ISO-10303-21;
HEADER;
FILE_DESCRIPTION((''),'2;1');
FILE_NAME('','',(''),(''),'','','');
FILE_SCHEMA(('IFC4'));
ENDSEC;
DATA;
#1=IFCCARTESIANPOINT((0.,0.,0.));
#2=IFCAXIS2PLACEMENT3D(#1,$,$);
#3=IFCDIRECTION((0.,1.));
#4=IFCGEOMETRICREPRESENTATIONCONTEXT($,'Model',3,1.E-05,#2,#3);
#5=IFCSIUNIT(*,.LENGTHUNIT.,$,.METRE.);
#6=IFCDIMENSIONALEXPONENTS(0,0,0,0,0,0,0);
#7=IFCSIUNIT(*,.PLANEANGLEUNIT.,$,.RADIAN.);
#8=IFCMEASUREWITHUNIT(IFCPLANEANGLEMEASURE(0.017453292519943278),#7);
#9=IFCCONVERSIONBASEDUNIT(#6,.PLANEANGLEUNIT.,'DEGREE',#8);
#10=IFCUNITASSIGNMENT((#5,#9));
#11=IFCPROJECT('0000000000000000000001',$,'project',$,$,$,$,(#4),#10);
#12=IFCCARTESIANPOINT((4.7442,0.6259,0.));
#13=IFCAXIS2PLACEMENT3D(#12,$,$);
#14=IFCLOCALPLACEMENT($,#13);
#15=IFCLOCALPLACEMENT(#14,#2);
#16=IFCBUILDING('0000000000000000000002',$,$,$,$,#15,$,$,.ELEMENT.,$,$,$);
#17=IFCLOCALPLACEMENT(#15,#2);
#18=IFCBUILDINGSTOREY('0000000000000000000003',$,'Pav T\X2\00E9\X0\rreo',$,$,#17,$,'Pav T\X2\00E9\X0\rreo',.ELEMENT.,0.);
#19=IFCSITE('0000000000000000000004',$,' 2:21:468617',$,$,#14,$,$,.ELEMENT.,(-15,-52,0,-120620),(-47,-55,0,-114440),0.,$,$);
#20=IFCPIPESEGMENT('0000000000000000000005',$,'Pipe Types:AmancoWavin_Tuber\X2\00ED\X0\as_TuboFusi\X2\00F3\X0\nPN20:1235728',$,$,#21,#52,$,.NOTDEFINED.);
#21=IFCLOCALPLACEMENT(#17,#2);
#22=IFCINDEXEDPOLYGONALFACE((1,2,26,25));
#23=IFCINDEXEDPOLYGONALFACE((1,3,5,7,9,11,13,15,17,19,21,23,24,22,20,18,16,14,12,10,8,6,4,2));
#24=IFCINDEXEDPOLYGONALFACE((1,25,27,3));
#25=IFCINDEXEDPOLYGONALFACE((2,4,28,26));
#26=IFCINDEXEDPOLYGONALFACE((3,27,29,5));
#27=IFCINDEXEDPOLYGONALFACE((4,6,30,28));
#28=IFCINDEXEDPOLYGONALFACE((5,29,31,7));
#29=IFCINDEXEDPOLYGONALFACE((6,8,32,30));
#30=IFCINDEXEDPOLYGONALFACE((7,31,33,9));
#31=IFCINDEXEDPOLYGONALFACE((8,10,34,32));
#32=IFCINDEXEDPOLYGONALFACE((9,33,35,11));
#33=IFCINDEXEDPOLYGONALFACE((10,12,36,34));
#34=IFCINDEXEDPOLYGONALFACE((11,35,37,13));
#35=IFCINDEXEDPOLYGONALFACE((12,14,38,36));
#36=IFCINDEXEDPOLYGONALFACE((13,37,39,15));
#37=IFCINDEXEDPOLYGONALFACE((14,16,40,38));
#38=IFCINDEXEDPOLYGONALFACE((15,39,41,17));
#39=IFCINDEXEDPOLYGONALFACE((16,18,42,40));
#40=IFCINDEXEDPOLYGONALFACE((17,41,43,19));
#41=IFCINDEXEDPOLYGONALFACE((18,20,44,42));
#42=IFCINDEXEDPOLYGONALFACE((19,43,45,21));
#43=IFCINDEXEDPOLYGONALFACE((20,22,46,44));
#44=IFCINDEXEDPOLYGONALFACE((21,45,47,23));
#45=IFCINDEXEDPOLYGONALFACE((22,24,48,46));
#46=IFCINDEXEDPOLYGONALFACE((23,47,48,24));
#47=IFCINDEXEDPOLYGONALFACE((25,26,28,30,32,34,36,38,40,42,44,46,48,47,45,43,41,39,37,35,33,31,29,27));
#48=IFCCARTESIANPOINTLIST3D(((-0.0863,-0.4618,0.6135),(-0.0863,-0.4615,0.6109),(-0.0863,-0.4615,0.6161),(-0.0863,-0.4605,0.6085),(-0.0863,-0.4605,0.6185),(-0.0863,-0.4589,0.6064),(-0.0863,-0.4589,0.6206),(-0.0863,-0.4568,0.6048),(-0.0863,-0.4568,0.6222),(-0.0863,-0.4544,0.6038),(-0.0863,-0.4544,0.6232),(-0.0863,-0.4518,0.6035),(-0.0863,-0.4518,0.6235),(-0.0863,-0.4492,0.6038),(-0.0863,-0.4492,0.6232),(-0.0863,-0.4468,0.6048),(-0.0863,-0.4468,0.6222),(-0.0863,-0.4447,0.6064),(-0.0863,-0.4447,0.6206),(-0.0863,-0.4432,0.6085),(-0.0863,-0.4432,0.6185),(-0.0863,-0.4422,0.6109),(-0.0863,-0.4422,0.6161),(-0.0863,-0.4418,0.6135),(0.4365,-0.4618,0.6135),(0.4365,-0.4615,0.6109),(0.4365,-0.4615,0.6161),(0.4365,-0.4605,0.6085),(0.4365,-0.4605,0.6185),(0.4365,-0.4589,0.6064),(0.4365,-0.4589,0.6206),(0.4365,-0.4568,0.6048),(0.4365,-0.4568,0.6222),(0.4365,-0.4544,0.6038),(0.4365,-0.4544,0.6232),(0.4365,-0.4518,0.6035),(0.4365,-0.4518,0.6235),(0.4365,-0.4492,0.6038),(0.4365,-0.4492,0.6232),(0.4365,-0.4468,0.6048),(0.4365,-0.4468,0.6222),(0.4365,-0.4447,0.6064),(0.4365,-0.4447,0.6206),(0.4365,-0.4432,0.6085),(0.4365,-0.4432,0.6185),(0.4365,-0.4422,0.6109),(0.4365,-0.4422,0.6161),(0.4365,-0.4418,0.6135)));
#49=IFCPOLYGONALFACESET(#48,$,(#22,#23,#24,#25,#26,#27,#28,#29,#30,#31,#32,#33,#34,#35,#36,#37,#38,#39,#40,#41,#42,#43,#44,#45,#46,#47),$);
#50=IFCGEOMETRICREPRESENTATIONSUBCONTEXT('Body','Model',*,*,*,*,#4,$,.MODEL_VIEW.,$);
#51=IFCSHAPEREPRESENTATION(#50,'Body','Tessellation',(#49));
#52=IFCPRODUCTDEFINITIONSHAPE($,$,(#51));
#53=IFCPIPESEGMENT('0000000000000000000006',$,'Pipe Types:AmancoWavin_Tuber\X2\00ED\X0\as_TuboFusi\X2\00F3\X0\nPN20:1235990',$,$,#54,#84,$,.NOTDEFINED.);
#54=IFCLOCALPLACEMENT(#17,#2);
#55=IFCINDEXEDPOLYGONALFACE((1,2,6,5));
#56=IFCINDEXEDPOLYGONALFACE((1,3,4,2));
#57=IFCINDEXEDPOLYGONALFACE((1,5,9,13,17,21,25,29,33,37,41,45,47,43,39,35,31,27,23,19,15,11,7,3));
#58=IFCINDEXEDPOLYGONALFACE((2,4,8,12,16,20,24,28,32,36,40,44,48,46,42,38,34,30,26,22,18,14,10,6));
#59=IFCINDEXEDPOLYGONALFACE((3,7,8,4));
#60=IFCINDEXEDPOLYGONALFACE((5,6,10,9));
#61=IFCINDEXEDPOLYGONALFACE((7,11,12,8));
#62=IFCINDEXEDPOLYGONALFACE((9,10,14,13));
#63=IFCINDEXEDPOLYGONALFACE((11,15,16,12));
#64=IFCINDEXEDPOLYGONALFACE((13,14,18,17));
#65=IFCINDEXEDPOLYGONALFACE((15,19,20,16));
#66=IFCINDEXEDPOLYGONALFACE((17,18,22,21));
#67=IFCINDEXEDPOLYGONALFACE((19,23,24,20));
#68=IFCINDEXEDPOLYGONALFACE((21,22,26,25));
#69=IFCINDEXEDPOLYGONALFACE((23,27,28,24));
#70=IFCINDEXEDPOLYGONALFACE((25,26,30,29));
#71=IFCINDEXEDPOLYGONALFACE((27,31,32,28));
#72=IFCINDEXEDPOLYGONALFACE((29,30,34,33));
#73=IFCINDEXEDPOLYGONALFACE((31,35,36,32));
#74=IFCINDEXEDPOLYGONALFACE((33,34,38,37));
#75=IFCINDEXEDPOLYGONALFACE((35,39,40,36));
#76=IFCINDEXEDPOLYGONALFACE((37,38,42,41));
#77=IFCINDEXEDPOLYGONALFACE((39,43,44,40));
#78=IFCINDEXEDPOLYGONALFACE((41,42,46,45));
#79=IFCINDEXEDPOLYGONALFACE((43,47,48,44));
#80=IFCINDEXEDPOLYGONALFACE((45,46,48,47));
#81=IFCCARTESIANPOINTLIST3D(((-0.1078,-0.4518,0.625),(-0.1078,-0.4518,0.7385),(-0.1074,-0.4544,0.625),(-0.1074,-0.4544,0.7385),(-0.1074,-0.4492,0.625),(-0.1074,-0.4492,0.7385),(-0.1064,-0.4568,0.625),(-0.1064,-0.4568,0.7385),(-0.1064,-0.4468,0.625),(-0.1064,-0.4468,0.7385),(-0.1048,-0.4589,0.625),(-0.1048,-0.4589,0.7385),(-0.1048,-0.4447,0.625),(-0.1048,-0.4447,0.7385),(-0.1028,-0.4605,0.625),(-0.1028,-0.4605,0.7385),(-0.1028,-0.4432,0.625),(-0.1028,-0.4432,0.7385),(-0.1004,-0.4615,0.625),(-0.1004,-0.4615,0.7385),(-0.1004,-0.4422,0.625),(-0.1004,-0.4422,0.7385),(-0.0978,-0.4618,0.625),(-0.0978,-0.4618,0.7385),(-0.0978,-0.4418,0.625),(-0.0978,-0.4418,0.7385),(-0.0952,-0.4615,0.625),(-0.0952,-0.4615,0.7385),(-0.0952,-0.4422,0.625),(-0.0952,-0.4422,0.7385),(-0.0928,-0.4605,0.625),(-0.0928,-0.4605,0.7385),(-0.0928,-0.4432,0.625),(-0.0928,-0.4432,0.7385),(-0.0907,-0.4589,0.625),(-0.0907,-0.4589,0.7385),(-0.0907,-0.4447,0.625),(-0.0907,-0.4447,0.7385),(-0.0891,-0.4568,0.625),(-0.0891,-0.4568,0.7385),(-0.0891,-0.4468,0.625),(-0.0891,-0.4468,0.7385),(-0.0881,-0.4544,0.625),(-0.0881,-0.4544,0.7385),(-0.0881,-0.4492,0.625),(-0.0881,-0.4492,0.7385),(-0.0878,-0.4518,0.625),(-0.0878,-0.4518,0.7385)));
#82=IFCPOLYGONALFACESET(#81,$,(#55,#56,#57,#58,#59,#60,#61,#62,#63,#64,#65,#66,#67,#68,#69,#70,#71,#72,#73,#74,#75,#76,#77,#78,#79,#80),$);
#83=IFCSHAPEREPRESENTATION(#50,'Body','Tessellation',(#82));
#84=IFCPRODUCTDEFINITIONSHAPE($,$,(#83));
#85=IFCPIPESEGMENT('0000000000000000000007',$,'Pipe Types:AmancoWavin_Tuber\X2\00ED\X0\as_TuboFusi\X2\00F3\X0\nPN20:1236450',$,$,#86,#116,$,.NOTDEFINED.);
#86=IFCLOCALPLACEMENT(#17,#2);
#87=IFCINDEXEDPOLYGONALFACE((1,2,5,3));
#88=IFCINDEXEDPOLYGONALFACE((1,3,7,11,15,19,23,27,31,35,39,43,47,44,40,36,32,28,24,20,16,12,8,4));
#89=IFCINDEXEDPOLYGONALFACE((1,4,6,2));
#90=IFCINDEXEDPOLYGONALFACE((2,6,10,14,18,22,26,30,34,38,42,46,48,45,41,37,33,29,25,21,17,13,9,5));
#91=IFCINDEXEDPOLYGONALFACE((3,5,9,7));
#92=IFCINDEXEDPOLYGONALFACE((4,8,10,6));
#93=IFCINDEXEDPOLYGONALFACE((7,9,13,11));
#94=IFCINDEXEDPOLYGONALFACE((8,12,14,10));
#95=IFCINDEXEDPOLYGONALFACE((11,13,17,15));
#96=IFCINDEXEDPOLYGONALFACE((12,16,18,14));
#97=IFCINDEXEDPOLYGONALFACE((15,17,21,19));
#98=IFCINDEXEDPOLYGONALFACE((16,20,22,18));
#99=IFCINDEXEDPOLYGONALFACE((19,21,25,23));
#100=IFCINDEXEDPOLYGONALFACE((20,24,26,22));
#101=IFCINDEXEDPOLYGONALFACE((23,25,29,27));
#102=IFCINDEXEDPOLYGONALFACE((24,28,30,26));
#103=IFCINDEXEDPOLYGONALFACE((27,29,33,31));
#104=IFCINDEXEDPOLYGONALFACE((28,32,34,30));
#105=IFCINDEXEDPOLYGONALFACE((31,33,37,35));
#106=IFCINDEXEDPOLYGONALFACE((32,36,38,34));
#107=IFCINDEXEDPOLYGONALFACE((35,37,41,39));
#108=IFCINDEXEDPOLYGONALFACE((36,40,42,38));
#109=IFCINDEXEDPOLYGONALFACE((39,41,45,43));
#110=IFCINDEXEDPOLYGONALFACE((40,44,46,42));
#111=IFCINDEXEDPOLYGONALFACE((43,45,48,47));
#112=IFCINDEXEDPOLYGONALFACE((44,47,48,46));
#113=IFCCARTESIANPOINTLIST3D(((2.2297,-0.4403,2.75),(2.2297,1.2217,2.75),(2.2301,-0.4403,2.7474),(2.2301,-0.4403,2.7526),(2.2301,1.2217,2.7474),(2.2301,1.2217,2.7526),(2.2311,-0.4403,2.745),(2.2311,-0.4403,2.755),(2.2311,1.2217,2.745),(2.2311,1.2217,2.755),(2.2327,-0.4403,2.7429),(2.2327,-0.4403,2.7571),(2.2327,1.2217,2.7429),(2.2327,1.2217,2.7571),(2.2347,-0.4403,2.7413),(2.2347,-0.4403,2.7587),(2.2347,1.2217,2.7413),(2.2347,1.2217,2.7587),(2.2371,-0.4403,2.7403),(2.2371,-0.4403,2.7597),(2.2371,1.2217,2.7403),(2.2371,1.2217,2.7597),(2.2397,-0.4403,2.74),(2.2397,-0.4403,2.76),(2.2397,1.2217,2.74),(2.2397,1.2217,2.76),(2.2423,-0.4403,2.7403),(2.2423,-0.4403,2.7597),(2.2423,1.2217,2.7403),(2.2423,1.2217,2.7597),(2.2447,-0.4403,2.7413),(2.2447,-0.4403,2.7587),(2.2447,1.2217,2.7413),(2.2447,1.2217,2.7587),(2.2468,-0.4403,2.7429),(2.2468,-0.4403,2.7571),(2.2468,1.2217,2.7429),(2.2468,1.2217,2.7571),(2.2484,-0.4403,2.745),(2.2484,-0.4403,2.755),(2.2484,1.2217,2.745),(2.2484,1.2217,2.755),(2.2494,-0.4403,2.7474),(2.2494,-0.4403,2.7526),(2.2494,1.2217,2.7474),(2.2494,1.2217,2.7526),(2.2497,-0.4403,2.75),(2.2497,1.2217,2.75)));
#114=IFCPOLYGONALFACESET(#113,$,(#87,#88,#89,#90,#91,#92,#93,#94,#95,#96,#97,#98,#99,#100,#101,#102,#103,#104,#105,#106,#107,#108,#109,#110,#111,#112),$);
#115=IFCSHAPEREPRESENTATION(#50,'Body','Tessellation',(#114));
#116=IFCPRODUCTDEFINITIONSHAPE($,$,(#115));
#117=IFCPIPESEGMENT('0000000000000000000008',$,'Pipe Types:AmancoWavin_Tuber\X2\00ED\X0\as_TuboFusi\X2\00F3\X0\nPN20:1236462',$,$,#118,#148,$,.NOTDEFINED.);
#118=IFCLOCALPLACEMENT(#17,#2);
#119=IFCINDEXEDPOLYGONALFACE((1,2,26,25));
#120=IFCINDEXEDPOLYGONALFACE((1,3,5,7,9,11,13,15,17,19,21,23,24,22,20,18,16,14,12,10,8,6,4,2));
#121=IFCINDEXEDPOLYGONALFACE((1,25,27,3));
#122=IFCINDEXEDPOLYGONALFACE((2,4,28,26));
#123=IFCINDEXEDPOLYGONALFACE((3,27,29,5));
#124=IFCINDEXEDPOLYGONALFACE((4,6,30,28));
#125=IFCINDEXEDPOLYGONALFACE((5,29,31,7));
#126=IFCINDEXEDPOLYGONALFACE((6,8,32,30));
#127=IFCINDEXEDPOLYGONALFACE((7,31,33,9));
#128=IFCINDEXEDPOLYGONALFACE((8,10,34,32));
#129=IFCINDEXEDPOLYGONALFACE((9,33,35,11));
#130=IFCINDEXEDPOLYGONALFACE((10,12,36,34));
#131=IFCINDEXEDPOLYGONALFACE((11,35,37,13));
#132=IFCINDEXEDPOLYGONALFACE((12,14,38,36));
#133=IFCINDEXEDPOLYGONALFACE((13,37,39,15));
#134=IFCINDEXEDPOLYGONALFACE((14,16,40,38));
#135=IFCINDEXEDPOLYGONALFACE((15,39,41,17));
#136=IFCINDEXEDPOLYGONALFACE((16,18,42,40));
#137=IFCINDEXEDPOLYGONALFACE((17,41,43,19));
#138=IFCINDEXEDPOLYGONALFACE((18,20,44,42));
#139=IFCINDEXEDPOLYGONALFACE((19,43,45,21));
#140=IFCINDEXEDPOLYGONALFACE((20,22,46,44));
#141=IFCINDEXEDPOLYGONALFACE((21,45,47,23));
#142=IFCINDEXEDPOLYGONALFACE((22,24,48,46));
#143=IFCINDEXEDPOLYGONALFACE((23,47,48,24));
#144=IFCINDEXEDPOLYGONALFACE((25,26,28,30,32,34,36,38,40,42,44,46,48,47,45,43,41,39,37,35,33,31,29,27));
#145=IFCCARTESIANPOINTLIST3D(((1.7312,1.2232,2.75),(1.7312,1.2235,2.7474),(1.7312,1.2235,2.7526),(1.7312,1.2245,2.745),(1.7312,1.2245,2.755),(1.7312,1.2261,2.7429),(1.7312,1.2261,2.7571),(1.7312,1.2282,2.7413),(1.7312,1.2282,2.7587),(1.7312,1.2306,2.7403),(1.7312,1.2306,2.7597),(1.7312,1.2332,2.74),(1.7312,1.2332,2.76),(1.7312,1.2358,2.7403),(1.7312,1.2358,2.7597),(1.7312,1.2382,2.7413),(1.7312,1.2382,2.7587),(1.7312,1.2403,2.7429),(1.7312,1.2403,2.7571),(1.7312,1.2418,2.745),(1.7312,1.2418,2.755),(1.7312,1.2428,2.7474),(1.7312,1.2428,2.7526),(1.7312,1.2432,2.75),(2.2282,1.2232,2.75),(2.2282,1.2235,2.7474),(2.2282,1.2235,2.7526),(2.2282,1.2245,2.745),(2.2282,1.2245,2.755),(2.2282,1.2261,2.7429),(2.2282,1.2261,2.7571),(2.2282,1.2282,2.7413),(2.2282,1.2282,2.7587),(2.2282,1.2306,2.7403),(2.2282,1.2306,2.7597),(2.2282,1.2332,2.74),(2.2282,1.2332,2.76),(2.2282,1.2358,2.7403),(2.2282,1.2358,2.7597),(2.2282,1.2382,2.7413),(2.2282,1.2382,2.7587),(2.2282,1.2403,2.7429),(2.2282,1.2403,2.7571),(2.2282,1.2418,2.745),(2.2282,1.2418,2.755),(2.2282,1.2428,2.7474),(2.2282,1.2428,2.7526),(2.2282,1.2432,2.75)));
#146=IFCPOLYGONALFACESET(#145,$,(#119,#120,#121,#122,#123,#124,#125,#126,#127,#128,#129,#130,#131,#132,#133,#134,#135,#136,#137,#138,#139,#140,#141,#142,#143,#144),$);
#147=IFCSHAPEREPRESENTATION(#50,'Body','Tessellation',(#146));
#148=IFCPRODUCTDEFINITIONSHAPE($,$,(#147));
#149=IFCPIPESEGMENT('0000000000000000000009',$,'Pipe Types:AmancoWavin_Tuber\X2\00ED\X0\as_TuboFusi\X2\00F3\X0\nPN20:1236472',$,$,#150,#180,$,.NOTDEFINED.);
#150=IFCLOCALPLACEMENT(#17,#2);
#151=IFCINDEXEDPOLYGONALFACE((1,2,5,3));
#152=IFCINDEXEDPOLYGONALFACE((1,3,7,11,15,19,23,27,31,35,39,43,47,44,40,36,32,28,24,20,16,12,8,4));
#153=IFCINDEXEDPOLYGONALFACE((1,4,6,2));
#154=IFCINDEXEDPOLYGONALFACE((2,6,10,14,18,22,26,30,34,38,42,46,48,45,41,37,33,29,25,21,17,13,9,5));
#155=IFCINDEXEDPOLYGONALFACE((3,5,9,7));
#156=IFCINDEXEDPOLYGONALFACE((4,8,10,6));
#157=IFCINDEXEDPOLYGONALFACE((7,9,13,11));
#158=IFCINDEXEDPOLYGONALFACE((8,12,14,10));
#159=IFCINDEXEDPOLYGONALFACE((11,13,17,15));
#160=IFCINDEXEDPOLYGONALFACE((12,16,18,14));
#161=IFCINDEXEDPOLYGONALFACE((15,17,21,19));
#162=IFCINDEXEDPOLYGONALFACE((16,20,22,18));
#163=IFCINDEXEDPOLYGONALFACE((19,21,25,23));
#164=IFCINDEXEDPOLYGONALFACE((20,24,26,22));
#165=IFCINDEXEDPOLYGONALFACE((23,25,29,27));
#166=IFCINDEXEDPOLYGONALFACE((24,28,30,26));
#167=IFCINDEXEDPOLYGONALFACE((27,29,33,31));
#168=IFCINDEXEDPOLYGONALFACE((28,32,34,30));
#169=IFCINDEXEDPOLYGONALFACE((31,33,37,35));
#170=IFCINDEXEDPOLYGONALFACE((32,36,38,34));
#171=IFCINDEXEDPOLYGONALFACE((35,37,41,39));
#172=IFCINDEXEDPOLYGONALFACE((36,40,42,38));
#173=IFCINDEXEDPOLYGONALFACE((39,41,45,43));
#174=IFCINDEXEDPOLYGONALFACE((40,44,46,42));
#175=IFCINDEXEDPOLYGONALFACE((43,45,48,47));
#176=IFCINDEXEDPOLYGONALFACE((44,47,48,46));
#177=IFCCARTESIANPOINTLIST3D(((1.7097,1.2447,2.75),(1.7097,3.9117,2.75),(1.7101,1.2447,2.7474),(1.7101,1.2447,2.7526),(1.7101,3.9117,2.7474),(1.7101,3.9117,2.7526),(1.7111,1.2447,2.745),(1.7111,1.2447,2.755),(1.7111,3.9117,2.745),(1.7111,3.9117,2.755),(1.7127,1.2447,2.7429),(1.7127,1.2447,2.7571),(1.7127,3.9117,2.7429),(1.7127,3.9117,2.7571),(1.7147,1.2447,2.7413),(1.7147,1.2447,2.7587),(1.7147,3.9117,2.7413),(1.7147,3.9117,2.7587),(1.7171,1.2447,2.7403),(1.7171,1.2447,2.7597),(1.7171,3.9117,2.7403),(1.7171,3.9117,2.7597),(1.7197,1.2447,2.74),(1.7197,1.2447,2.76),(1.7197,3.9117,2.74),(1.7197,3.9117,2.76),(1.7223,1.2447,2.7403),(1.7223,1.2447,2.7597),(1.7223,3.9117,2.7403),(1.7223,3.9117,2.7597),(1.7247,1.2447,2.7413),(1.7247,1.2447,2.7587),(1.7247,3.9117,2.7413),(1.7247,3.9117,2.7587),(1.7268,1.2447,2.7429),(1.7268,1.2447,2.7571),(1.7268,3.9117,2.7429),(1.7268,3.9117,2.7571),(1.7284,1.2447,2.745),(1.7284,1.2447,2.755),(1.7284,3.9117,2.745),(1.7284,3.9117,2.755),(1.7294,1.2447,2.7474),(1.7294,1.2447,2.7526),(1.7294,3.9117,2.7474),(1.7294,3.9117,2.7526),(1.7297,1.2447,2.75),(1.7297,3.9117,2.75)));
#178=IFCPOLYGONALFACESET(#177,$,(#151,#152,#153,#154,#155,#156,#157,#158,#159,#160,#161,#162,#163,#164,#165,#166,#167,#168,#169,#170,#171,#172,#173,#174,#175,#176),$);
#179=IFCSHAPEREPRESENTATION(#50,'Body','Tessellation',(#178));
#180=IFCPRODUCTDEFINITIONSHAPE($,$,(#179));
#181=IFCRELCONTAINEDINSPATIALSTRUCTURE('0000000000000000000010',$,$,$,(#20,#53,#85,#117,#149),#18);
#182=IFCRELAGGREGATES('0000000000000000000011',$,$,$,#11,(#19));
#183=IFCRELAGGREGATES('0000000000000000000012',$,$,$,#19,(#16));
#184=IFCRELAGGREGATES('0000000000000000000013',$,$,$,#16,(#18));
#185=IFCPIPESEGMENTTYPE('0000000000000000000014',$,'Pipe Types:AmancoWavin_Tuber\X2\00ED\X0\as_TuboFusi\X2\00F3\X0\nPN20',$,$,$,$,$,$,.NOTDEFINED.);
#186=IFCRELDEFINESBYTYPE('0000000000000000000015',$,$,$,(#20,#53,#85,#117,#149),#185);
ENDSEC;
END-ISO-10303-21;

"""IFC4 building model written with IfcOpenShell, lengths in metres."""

from ifc_helpers import new_model, entity, si_unit, converted_unit, direction, frame, origin, place, context, subcontext, project, spatial, arc, indexed_curve, outline, extrude, type_object, element, save


model = new_model("IFC4")

# Units and contexts
model_context = context("Model", 3, precision=1e-05, world=origin(), true_north=direction((0.0, 1.0)))
body_context = subcontext(model_context, "Body", "Model", "MODEL_VIEW")
ifc_project = project(units=[si_unit("LENGTHUNIT", "METRE"), converted_unit("PLANEANGLEUNIT", "DEGREE", entity("IfcPlaneAngleMeasure", 0.017453292519943278), si_unit("PLANEANGLEUNIT", "RADIAN"), dimensions=[0, 0, 0, 0, 0, 0, 0])], contexts=[model_context])

# Site, building, storey
site_placement = place(None, frame((4.7442, 0.6259, 0.0)))
site = spatial("IfcSite", under=ifc_project, at=site_placement, Name=" 2:21:468617", CompositionType="ELEMENT", RefLatitude=(-15, -52, 0, -120620), RefLongitude=(-47, -55, 0, -114440), RefElevation=0.0)
building_placement = place(site_placement, origin())
building = spatial("IfcBuilding", under=site, at=building_placement, CompositionType="ELEMENT")
storey_placement = place(building_placement, origin())
storey = spatial("IfcBuildingStorey", under=building, at=storey_placement, Name="Pav Térreo", LongName="Pav Térreo", CompositionType="ELEMENT", Elevation=0.0)

# Pipe segments
pipe_segment_type_1 = type_object("IfcPipeSegmentType", Name="Pipe Types:AmancoWavin_Tuberías_TuboFusiónPN20", PredefinedType="NOTDEFINED")
pipe_segment_1_placement = place(storey_placement, origin())
element("IfcPipeSegment", 1, at=pipe_segment_1_placement, inside=storey, type_object=pipe_segment_type_1, Name="Pipe Types:AmancoWavin_Tuberías_TuboFusiónPN20:1235728", PredefinedType="NOTDEFINED", context=body_context, shape_type="SweptSolid", body=[
    extrude(outline(indexed_curve([(0.01, 0.0), (0.0071, 0.0071), (0.0, 0.01), (-0.0071, 0.0071), (-0.01, 0.0), (-0.0071, -0.0071), (0.0, -0.01), (0.0071, -0.0071)], segments=[arc(1, 2, 3), arc(3, 4, 5), arc(5, 6, 7), arc(7, 8, 1)], self_intersect=False)), frame((-0.0863, -0.4518, 0.6135), z_axis=(1.0, 0.0, 0.0), x_axis=(0.0, 1.0, 0.0)), (0.0, 0.0, 1.0), 0.5228),
])
pipe_segment_2_placement = place(storey_placement, origin())
element("IfcPipeSegment", 2, at=pipe_segment_2_placement, inside=storey, type_object=pipe_segment_type_1, Name="Pipe Types:AmancoWavin_Tuberías_TuboFusiónPN20:1235990", PredefinedType="NOTDEFINED", context=body_context, shape_type="SweptSolid", body=[
    extrude(outline(indexed_curve([(0.01, 0.0), (0.0071, 0.0071), (0.0, 0.01), (-0.0071, 0.0071), (-0.01, 0.0), (-0.0071, -0.0071), (0.0, -0.01), (0.0071, -0.0071)], segments=[arc(1, 2, 3), arc(3, 4, 5), arc(5, 6, 7), arc(7, 8, 1)], self_intersect=False)), frame((-0.0978, -0.4518, 0.625), z_axis=(0.0, 0.0, 1.0), x_axis=(-1.0, 0.0, 0.0)), (0.0, 0.0, 1.0), 0.1135),
])
pipe_segment_3_placement = place(storey_placement, origin())
element("IfcPipeSegment", 3, at=pipe_segment_3_placement, inside=storey, type_object=pipe_segment_type_1, Name="Pipe Types:AmancoWavin_Tuberías_TuboFusiónPN20:1236450", PredefinedType="NOTDEFINED", context=body_context, shape_type="SweptSolid", body=[
    extrude(outline(indexed_curve([(0.01, 0.0), (0.0071, 0.0071), (0.0, 0.01), (-0.0071, 0.0071), (-0.01, 0.0), (-0.0071, -0.0071), (0.0, -0.01), (0.0071, -0.0071)], segments=[arc(1, 2, 3), arc(3, 4, 5), arc(5, 6, 7), arc(7, 8, 1)], self_intersect=False)), frame((2.2397, -0.4403, 2.75), z_axis=(0.0, 1.0, 0.0), x_axis=(1.0, 0.0, 0.0)), (0.0, 0.0, 1.0), 1.662),
])
pipe_segment_4_placement = place(storey_placement, origin())
element("IfcPipeSegment", 4, at=pipe_segment_4_placement, inside=storey, type_object=pipe_segment_type_1, Name="Pipe Types:AmancoWavin_Tuberías_TuboFusiónPN20:1236462", PredefinedType="NOTDEFINED", context=body_context, shape_type="SweptSolid", body=[
    extrude(outline(indexed_curve([(0.01, 0.0), (0.0071, 0.0071), (0.0, 0.01), (-0.0071, 0.0071), (-0.01, 0.0), (-0.0071, -0.0071), (0.0, -0.01), (0.0071, -0.0071)], segments=[arc(1, 2, 3), arc(3, 4, 5), arc(5, 6, 7), arc(7, 8, 1)], self_intersect=False)), frame((1.7312, 1.2332, 2.75), z_axis=(1.0, 0.0, 0.0), x_axis=(0.0, 1.0, 0.0)), (0.0, 0.0, 1.0), 0.497),
])
pipe_segment_5_placement = place(storey_placement, origin())
element("IfcPipeSegment", 5, at=pipe_segment_5_placement, inside=storey, type_object=pipe_segment_type_1, Name="Pipe Types:AmancoWavin_Tuberías_TuboFusiónPN20:1236472", PredefinedType="NOTDEFINED", context=body_context, shape_type="SweptSolid", body=[
    extrude(outline(indexed_curve([(0.01, 0.0), (0.0071, 0.0071), (0.0, 0.01), (-0.0071, 0.0071), (-0.01, 0.0), (-0.0071, -0.0071), (0.0, -0.01), (0.0071, -0.0071)], segments=[arc(1, 2, 3), arc(3, 4, 5), arc(5, 6, 7), arc(7, 8, 1)], self_intersect=False)), frame((1.7197, 1.2447, 2.75), z_axis=(0.0, 1.0, 0.0), x_axis=(1.0, 0.0, 0.0)), (0.0, 0.0, 1.0), 2.667),
])

save(model, "model.ifc")
